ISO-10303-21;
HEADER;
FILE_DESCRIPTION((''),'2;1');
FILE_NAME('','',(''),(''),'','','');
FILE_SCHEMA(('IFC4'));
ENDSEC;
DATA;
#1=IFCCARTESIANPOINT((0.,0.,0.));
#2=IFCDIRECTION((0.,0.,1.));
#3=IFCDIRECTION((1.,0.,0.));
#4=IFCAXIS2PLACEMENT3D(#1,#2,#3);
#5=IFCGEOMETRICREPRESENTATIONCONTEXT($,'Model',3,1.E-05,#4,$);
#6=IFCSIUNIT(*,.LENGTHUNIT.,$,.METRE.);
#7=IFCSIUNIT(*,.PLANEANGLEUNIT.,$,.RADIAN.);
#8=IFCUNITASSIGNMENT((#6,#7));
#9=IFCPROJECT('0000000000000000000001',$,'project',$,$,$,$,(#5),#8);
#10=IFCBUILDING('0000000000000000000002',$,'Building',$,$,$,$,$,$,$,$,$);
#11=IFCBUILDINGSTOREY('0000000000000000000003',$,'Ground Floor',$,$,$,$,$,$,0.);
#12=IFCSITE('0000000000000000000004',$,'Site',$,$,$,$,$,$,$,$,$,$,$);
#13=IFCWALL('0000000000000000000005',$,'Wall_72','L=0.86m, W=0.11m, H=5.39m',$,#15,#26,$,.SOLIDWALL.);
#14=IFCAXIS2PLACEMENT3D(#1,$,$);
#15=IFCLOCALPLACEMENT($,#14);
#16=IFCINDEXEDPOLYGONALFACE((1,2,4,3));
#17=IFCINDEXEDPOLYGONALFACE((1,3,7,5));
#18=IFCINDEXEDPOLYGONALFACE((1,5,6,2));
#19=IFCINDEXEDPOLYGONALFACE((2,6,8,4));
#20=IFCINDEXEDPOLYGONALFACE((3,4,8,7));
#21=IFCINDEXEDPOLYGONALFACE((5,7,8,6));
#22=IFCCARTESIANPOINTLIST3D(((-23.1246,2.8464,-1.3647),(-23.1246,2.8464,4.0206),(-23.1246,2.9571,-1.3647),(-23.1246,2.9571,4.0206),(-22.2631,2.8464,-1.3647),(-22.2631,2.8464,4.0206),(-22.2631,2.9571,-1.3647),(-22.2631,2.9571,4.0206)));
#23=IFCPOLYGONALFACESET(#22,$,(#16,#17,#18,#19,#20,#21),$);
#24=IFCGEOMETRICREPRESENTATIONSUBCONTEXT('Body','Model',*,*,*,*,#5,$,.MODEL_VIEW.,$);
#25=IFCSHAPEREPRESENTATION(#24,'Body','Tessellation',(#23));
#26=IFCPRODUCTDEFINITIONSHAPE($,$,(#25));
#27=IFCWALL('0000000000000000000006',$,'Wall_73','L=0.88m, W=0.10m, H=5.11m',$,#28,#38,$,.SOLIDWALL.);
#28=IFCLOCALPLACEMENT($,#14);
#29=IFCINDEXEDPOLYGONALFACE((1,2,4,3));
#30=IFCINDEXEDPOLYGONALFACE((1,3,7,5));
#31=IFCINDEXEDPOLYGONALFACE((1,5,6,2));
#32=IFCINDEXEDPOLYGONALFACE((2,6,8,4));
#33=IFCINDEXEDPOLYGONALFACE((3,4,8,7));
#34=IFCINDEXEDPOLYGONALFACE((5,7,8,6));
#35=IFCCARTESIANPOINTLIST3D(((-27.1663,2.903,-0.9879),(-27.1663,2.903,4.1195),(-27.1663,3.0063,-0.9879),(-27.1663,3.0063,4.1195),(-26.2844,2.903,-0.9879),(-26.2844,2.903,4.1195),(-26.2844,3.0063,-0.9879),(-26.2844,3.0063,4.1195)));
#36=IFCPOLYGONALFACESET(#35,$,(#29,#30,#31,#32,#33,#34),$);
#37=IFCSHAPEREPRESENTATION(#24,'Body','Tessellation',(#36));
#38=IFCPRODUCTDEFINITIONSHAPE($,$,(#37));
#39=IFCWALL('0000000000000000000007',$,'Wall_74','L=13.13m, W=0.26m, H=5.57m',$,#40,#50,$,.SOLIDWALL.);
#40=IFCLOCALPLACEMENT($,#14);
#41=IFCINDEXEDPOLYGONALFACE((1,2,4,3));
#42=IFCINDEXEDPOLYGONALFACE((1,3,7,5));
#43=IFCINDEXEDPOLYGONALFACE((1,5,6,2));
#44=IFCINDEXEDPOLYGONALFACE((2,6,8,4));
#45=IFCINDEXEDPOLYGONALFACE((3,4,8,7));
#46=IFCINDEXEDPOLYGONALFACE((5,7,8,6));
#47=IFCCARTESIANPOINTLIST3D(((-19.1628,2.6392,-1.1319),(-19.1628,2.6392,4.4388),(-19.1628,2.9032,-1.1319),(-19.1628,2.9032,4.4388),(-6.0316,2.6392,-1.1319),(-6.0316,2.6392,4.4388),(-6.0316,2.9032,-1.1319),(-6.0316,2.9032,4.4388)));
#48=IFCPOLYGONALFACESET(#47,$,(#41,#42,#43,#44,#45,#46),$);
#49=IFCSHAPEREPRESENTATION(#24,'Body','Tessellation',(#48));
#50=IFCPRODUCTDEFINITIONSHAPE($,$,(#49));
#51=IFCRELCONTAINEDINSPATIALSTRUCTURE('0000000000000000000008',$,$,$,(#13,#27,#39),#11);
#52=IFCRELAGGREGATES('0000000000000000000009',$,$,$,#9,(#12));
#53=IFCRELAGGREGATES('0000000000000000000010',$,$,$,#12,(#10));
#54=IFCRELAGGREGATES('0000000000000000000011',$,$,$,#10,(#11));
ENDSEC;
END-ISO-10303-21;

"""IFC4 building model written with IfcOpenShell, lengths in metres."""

from ifc_helpers import new_model, si_unit, frame, origin_with_axes, origin_2d, context, subcontext, project, spatial, rectangle, extrude, element, save


model = new_model("IFC4")

# Units and contexts
model_context = context("Model", 3, precision=1e-05, world=origin_with_axes())
body_context = subcontext(model_context, "Body", "Model", "MODEL_VIEW")
ifc_project = project(units=[si_unit("LENGTHUNIT", "METRE"), si_unit("PLANEANGLEUNIT", "RADIAN")], contexts=[model_context])

# Site, building, storey
site = spatial("IfcSite", under=ifc_project, Name="Site")
building = spatial("IfcBuilding", under=site, Name="Building")
storey = spatial("IfcBuildingStorey", under=building, Name="Ground Floor", Elevation=0.0)

# Walls
element("IfcWall", 1, inside=storey, Name="Wall_72", Description="L=0.86m, W=0.11m, H=5.39m", PredefinedType="SOLIDWALL", context=body_context, shape_type="SweptSolid", body=[
    extrude(rectangle(XDim=0.8615, YDim=0.1107, at=origin_2d()), frame((-22.6939, 2.9017, -1.3647), z_axis=(0.0, 0.0, 1.0), x_axis=(1.0, 0.0, 0.0)), (0.0, 0.0, 1.0), 5.3853),
])
element("IfcWall", 2, inside=storey, Name="Wall_73", Description="L=0.88m, W=0.10m, H=5.11m", PredefinedType="SOLIDWALL", context=body_context, shape_type="SweptSolid", body=[
    extrude(rectangle(XDim=0.8819, YDim=0.1033, at=origin_2d()), frame((-26.7254, 2.9547, -0.9879), z_axis=(0.0, 0.0, 1.0), x_axis=(1.0, 0.0, 0.0)), (0.0, 0.0, 1.0), 5.1075),
])
element("IfcWall", 3, inside=storey, Name="Wall_74", Description="L=13.13m, W=0.26m, H=5.57m", PredefinedType="SOLIDWALL", context=body_context, shape_type="SweptSolid", body=[
    extrude(rectangle(XDim=13.1312, YDim=0.264, at=origin_2d()), frame((-12.5972, 2.7712, -1.1319), z_axis=(0.0, 0.0, 1.0), x_axis=(1.0, 0.0, 0.0)), (0.0, 0.0, 1.0), 5.5707),
])

save(model, "model.ifc")
